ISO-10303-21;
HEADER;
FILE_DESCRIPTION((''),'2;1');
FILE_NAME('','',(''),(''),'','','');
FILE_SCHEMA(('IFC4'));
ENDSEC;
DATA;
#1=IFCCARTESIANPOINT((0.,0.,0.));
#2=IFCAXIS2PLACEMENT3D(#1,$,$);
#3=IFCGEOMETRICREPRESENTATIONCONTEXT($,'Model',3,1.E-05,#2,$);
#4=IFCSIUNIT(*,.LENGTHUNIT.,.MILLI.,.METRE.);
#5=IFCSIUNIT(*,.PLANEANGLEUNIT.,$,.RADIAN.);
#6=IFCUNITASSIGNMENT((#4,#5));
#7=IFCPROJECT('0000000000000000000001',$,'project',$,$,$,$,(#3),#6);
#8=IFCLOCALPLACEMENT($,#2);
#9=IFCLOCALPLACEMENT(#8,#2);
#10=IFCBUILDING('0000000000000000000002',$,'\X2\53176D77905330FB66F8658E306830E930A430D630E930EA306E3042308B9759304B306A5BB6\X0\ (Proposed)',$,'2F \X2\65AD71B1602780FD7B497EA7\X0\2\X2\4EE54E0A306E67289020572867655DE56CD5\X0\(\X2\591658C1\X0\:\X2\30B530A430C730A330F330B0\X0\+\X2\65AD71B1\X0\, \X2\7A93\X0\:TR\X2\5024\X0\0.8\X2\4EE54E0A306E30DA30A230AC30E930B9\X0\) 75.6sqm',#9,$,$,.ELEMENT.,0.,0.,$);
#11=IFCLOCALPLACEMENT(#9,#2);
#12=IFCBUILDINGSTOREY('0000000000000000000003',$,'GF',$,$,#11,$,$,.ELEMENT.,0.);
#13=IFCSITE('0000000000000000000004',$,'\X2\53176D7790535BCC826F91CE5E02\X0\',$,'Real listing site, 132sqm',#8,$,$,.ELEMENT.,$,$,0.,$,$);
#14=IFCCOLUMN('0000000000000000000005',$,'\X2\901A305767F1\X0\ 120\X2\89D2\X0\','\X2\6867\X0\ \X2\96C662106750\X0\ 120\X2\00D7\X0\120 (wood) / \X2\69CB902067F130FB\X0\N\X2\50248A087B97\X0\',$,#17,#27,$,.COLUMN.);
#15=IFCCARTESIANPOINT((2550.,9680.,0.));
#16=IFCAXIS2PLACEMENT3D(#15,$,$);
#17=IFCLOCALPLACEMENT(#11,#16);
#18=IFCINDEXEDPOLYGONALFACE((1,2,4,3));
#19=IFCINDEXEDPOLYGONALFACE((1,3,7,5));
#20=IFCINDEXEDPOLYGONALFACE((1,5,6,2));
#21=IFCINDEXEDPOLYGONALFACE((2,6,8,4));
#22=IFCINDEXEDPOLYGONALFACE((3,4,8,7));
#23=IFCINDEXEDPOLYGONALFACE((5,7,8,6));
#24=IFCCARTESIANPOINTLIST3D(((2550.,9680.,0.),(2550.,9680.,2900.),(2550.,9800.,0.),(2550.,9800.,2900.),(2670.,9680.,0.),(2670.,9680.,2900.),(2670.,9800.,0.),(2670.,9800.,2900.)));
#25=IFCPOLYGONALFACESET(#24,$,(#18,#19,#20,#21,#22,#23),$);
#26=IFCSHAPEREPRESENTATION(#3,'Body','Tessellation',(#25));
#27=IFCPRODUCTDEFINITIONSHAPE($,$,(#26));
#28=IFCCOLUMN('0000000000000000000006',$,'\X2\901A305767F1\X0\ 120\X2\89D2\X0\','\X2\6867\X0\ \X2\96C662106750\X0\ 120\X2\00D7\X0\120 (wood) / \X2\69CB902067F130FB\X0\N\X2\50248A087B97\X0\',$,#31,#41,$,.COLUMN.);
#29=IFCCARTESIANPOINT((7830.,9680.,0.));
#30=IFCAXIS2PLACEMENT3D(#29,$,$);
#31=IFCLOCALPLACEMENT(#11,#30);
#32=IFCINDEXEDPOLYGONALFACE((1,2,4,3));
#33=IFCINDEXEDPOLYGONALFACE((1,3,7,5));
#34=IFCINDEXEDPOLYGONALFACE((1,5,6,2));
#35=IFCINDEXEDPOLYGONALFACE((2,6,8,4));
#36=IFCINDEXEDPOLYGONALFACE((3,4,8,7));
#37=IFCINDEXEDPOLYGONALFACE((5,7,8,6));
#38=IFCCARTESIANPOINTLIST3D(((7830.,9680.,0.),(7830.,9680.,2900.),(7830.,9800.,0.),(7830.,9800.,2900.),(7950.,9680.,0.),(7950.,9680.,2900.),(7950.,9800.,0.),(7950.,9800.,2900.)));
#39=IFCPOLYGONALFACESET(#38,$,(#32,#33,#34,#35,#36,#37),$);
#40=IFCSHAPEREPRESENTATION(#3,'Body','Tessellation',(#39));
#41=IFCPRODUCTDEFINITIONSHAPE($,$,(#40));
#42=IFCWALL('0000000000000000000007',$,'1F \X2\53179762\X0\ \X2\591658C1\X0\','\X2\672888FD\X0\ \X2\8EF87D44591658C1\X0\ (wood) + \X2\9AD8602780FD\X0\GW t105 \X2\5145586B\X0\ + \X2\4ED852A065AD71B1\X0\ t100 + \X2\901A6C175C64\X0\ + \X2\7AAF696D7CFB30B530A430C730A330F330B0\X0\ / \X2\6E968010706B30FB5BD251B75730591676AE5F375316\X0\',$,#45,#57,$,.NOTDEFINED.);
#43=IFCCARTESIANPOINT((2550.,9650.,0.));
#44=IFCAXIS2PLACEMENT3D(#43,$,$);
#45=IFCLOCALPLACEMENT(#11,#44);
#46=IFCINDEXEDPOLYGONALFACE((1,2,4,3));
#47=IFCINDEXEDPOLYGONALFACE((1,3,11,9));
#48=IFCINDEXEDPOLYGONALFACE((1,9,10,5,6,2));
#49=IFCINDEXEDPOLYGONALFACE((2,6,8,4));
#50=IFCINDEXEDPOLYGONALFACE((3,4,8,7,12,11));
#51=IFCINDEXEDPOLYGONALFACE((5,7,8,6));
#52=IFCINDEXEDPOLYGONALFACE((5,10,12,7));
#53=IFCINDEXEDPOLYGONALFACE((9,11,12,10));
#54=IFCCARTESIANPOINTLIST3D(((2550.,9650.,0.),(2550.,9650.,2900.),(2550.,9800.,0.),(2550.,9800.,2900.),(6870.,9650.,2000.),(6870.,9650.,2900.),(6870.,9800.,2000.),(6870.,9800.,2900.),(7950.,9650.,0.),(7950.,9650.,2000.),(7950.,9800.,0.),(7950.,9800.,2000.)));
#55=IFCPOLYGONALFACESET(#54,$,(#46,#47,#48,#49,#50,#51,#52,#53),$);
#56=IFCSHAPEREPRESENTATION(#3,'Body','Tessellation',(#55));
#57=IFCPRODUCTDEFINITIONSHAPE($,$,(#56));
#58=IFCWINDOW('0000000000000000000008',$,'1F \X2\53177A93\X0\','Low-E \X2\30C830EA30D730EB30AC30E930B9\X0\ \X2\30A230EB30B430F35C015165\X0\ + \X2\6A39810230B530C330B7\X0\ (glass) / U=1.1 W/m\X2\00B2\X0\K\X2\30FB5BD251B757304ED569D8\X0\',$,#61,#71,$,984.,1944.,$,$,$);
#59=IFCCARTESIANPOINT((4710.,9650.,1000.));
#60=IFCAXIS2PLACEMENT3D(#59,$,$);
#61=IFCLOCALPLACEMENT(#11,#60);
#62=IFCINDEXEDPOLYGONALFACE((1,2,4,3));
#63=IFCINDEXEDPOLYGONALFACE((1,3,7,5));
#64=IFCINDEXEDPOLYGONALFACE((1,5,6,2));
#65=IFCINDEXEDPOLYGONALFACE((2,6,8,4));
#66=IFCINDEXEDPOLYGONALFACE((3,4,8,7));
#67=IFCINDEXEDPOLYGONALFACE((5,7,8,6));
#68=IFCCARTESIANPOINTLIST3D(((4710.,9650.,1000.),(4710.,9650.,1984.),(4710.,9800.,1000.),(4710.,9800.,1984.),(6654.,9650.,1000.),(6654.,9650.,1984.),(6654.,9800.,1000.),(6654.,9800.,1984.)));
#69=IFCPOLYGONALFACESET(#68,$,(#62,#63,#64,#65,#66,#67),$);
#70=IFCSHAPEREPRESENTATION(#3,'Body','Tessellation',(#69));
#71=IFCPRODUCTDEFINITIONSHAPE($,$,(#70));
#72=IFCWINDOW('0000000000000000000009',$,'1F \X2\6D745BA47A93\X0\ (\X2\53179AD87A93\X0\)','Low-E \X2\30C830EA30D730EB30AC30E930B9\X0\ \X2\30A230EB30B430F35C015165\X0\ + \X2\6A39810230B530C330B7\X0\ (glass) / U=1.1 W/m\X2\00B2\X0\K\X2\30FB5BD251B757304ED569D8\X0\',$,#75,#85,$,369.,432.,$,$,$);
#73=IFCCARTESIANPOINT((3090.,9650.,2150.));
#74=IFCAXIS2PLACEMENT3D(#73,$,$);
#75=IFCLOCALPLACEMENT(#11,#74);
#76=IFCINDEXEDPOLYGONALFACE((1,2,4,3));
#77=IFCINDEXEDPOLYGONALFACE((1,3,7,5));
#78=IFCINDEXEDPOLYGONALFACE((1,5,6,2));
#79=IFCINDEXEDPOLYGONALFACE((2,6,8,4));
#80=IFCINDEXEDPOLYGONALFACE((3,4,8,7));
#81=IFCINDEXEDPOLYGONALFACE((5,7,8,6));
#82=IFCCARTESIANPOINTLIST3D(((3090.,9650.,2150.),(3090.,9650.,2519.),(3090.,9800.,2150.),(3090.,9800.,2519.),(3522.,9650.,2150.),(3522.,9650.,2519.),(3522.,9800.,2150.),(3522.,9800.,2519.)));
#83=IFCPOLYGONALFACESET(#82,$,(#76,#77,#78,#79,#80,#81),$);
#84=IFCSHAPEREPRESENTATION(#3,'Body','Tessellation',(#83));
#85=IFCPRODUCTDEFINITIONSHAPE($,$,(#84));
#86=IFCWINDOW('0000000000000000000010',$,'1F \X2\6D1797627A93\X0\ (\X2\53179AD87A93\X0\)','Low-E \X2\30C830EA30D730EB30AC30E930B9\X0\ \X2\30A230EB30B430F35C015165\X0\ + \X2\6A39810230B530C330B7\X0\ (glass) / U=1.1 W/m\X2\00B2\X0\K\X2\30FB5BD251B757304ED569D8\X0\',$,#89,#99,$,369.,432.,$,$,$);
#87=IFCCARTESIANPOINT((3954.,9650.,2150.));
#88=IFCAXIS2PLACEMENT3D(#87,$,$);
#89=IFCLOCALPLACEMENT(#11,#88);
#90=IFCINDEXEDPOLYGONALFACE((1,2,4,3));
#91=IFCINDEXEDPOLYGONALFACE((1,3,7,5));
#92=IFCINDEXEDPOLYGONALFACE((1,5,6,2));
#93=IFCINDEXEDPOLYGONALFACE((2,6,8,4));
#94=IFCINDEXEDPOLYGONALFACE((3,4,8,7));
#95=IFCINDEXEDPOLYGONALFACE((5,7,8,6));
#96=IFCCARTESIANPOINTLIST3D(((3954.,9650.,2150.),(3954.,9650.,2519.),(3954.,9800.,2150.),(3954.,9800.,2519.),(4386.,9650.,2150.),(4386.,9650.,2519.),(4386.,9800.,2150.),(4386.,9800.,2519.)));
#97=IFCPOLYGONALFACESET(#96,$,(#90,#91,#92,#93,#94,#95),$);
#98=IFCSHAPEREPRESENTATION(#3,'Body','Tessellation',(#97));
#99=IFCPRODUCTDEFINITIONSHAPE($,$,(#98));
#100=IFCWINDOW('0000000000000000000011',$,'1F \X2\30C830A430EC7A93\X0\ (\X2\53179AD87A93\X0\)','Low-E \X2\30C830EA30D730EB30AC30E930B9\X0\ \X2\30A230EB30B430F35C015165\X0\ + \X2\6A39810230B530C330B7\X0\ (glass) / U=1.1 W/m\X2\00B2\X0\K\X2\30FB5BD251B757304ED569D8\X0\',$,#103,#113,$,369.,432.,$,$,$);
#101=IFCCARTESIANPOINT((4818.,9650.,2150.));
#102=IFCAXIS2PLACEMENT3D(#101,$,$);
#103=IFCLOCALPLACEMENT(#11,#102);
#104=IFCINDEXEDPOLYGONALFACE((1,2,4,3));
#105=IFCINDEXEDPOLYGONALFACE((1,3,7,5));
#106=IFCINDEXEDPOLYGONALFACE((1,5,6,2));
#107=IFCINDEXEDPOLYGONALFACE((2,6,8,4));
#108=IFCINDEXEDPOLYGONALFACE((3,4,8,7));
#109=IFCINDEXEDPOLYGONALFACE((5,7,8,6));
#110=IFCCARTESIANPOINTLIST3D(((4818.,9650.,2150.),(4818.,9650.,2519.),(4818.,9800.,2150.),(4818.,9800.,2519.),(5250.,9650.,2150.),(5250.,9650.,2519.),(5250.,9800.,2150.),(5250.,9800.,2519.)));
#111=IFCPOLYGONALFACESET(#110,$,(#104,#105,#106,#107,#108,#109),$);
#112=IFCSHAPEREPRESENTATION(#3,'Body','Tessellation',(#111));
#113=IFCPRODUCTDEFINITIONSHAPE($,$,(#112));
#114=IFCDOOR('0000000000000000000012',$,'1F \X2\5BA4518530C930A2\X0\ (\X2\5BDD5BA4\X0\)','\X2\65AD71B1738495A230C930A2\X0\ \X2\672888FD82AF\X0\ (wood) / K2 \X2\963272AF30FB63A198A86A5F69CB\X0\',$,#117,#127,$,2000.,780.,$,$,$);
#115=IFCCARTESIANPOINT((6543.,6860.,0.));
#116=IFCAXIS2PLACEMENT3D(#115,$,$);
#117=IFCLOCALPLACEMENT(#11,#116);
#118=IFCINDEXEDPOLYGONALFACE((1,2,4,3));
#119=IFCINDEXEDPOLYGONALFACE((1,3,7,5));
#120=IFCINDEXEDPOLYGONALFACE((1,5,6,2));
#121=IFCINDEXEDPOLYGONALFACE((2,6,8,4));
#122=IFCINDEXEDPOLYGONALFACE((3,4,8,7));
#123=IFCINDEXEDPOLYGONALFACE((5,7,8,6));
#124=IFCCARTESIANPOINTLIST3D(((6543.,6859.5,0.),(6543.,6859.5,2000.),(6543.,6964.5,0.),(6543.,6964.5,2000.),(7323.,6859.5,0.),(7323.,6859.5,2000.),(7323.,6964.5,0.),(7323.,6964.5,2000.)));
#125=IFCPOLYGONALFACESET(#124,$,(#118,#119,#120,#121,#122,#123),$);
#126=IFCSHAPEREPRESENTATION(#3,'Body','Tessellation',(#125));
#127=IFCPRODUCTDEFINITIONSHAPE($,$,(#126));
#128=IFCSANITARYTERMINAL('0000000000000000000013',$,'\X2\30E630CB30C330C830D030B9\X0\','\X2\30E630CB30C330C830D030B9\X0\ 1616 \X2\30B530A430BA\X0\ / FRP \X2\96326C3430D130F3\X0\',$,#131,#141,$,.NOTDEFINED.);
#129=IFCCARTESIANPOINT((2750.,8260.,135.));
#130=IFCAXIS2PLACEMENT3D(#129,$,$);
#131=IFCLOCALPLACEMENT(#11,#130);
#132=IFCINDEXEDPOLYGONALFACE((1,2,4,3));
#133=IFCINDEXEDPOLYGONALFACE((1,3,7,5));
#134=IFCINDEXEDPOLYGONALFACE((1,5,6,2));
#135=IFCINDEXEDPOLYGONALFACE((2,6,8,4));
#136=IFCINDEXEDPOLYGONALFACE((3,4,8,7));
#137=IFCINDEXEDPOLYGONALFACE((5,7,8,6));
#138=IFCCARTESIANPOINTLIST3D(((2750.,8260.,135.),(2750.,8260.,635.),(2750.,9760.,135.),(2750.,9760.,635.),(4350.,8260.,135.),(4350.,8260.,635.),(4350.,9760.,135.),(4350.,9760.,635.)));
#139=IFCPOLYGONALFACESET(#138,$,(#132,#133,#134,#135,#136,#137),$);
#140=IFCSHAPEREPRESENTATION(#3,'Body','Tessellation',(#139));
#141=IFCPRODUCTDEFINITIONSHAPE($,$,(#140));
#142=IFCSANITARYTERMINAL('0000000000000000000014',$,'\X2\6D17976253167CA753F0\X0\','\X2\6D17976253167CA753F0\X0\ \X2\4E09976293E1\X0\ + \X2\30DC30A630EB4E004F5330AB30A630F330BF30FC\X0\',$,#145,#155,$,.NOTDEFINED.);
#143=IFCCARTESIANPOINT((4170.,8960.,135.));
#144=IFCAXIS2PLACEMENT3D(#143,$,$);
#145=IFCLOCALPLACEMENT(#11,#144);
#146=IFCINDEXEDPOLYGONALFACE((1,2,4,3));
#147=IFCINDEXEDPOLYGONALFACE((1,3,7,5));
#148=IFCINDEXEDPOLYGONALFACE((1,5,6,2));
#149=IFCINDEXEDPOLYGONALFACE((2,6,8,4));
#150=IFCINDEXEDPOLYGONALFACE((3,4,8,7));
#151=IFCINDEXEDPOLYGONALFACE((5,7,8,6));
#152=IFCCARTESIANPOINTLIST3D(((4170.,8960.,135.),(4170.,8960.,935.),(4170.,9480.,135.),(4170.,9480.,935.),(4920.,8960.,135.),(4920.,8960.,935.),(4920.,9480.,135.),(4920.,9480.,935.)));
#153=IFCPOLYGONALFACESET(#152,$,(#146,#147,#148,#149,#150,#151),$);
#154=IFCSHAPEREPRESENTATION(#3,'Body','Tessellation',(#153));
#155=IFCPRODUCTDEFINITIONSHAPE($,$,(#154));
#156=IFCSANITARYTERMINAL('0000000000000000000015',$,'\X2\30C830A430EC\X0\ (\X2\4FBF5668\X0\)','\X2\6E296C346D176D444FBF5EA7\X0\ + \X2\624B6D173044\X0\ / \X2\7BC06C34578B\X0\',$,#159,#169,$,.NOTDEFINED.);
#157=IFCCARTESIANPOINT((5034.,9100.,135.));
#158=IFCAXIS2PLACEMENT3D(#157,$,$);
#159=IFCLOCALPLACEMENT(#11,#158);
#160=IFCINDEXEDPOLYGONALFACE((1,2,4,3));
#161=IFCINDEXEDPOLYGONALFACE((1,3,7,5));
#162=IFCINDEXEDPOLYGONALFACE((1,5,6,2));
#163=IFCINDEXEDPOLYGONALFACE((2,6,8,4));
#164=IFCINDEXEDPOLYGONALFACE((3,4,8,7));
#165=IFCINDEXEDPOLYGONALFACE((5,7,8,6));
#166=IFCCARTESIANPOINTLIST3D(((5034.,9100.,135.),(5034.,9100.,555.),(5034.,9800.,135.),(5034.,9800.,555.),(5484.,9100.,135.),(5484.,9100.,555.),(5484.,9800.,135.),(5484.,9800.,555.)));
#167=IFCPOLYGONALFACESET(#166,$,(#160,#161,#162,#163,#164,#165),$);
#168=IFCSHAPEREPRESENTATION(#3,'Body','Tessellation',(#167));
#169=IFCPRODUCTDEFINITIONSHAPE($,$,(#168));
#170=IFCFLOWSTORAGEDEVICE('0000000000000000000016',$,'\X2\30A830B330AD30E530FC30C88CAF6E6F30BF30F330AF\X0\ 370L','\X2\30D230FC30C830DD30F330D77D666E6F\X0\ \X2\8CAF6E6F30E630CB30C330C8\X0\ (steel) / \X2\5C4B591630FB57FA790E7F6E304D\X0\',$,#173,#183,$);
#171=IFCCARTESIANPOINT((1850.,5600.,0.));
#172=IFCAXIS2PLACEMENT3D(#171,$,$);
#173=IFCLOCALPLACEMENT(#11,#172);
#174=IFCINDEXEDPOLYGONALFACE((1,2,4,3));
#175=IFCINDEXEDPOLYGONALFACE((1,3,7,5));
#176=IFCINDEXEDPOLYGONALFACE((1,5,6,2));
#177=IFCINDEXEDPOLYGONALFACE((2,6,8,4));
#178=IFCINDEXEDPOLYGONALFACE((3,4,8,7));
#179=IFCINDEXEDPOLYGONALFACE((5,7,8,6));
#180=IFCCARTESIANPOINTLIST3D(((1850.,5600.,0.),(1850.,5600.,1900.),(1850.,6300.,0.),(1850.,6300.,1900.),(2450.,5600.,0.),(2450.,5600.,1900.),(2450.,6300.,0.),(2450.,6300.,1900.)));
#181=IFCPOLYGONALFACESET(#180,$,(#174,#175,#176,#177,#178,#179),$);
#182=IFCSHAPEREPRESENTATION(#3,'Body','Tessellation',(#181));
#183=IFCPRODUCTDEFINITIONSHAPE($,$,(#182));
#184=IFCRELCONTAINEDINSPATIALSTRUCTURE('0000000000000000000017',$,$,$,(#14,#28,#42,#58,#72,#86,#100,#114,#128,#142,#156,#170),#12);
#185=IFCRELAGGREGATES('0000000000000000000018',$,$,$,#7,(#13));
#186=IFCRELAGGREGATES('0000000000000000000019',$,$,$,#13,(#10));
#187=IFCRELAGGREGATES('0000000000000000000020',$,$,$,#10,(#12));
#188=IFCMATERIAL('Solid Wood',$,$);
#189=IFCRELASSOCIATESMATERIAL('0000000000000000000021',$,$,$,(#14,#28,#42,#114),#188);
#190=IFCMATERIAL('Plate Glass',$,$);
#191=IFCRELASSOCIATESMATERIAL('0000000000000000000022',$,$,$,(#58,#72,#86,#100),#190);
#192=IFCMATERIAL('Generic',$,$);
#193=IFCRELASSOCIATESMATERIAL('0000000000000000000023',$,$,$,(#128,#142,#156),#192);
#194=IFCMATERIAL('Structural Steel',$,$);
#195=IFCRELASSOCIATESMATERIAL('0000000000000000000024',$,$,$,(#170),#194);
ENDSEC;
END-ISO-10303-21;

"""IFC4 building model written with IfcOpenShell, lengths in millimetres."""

from ifc_helpers import new_model, si_unit, frame, frame_2d, origin, place, context, project, spatial, rectangle, extrude, material, element, fill, save


model = new_model("IFC4")

# Units and contexts
model_context = context("Model", 3, precision=1e-05, world=origin())
ifc_project = project(units=[si_unit("LENGTHUNIT", "METRE", prefix="MILLI"), si_unit("PLANEANGLEUNIT", "RADIAN")], contexts=[model_context])

# Site, building, storey
site_placement = place(None, origin())
site = spatial("IfcSite", under=ifc_project, at=site_placement, Name="北海道富良野市", ObjectType="Real listing site, 132sqm", CompositionType="ELEMENT", RefElevation=0.0)
building_placement = place(site_placement, origin())
building = spatial("IfcBuilding", under=site, at=building_placement, Name="北海道・書斎とライブラリのある静かな家 (Proposed)", ObjectType="2F 断熱性能等级2以上の木造在来工法(外壁:サイディング+断熱, 窓:TR値0.8以上のペアガラス) 75.6sqm", CompositionType="ELEMENT", ElevationOfRefHeight=0.0, ElevationOfTerrain=0.0)
storey_placement = place(building_placement, origin())
storey = spatial("IfcBuildingStorey", under=building, at=storey_placement, Name="GF", CompositionType="ELEMENT", Elevation=0.0)

# Columns
ifc_material_1 = material(Name="Solid Wood")
column_1_placement = place(storey_placement, frame((2550.0, 9680.0, 0.0)))
element("IfcColumn", 1, at=column_1_placement, inside=storey, material=ifc_material_1, Name="通し柱 120角", Description="桧 集成材 120×120 (wood) / 構造柱・N値計算", PredefinedType="COLUMN", context=model_context, shape_type="SweptSolid", body=[
    extrude(rectangle(XDim=120.0, YDim=120.0, at=frame_2d((60.0, 60.0))), frame((2550.0, 9680.0, 0.0)), (0.0, 0.0, 1.0), 2900.0),
])
column_2_placement = place(storey_placement, frame((7830.0, 9680.0, 0.0)))
element("IfcColumn", 2, at=column_2_placement, inside=storey, material=ifc_material_1, Name="通し柱 120角", Description="桧 集成材 120×120 (wood) / 構造柱・N値計算", PredefinedType="COLUMN", context=model_context, shape_type="SweptSolid", body=[
    extrude(rectangle(XDim=120.0, YDim=120.0, at=frame_2d((60.0, 60.0))), frame((7830.0, 9680.0, 0.0)), (0.0, 0.0, 1.0), 2900.0),
])

# Wall, openings, windows
wall_1_placement = place(storey_placement, frame((2550.0, 9650.0, 0.0)))
wall_1 = element("IfcWall", 3, at=wall_1_placement, inside=storey, material=ifc_material_1, Name="1F 北面 外壁", Description="木製 軸組外壁 (wood) + 高性能GW t105 充填 + 付加断熱 t100 + 通気層 + 窯業系サイディング / 準耐火・寒冷地外皮強化", PredefinedType="NOTDEFINED", context=model_context, shape_type="SweptSolid", body=[
    extrude(rectangle(XDim=5400.0, YDim=150.0, at=frame_2d((2700.0, 75.0))), frame((2550.0, 9650.0, 0.0)), (0.0, 0.0, 1.0), 2900.0),
])
opening_1_placement = place(storey_placement, frame((4710.0, 9650.0, 1000.0)))
opening_1 = element("IfcOpeningElement", 4, at=opening_1_placement, cuts=wall_1, PredefinedType="NOTDEFINED", context=model_context, shape_type="SweptSolid", body=[
    extrude(rectangle(XDim=1944.0, YDim=150.0, at=frame_2d((972.0, 75.0))), frame((4710.0, 9650.0, 1000.0)), (0.0, 0.0, 1.0), 984.0),
])
opening_2_placement = place(storey_placement, frame((3090.0, 9650.0, 2150.0)))
opening_2 = element("IfcOpeningElement", 5, at=opening_2_placement, cuts=wall_1, PredefinedType="NOTDEFINED", context=model_context, shape_type="SweptSolid", body=[
    extrude(rectangle(XDim=432.0, YDim=150.0, at=frame_2d((216.0, 75.0))), frame((3090.0, 9650.0, 2150.0)), (0.0, 0.0, 1.0), 369.0),
])
opening_3_placement = place(storey_placement, frame((3954.0, 9650.0, 2150.0)))
opening_3 = element("IfcOpeningElement", 6, at=opening_3_placement, cuts=wall_1, PredefinedType="NOTDEFINED", context=model_context, shape_type="SweptSolid", body=[
    extrude(rectangle(XDim=432.0, YDim=150.0, at=frame_2d((216.0, 75.0))), frame((3954.0, 9650.0, 2150.0)), (0.0, 0.0, 1.0), 369.0),
])
opening_4_placement = place(storey_placement, frame((4818.0, 9650.0, 2150.0)))
opening_4 = element("IfcOpeningElement", 7, at=opening_4_placement, cuts=wall_1, PredefinedType="NOTDEFINED", context=model_context, shape_type="SweptSolid", body=[
    extrude(rectangle(XDim=432.0, YDim=150.0, at=frame_2d((216.0, 75.0))), frame((4818.0, 9650.0, 2150.0)), (0.0, 0.0, 1.0), 369.0),
])
ifc_material_2 = material(Name="Plate Glass")
window_1_placement = place(storey_placement, frame((4710.0, 9650.0, 1000.0)))
window_1 = element("IfcWindow", 8, at=window_1_placement, inside=storey, material=ifc_material_2, Name="1F 北窓", Description="Low-E トリプルガラス アルゴン封入 + 樹脂サッシ (glass) / U=1.1 W/m²K・寒冷地仕様", OverallHeight=984.0, OverallWidth=1944.0, context=model_context, shape_type="SweptSolid", body=[
    extrude(rectangle(XDim=1944.0, YDim=150.0, at=frame_2d((972.0, 75.0))), frame((4710.0, 9650.0, 1000.0)), (0.0, 0.0, 1.0), 984.0),
])
fill(opening_1, window_1)
window_2_placement = place(storey_placement, frame((3090.0, 9650.0, 2150.0)))
window_2 = element("IfcWindow", 9, at=window_2_placement, inside=storey, material=ifc_material_2, Name="1F 浴室窓 (北高窓)", Description="Low-E トリプルガラス アルゴン封入 + 樹脂サッシ (glass) / U=1.1 W/m²K・寒冷地仕様", OverallHeight=369.0, OverallWidth=432.0, context=model_context, shape_type="SweptSolid", body=[
    extrude(rectangle(XDim=432.0, YDim=150.0, at=frame_2d((216.0, 75.0))), frame((3090.0, 9650.0, 2150.0)), (0.0, 0.0, 1.0), 369.0),
])
fill(opening_2, window_2)
window_3_placement = place(storey_placement, frame((3954.0, 9650.0, 2150.0)))
window_3 = element("IfcWindow", 10, at=window_3_placement, inside=storey, material=ifc_material_2, Name="1F 洗面窓 (北高窓)", Description="Low-E トリプルガラス アルゴン封入 + 樹脂サッシ (glass) / U=1.1 W/m²K・寒冷地仕様", OverallHeight=369.0, OverallWidth=432.0, context=model_context, shape_type="SweptSolid", body=[
    extrude(rectangle(XDim=432.0, YDim=150.0, at=frame_2d((216.0, 75.0))), frame((3954.0, 9650.0, 2150.0)), (0.0, 0.0, 1.0), 369.0),
])
fill(opening_3, window_3)
window_4_placement = place(storey_placement, frame((4818.0, 9650.0, 2150.0)))
window_4 = element("IfcWindow", 11, at=window_4_placement, inside=storey, material=ifc_material_2, Name="1F トイレ窓 (北高窓)", Description="Low-E トリプルガラス アルゴン封入 + 樹脂サッシ (glass) / U=1.1 W/m²K・寒冷地仕様", OverallHeight=369.0, OverallWidth=432.0, context=model_context, shape_type="SweptSolid", body=[
    extrude(rectangle(XDim=432.0, YDim=150.0, at=frame_2d((216.0, 75.0))), frame((4818.0, 9650.0, 2150.0)), (0.0, 0.0, 1.0), 369.0),
])
fill(opening_4, window_4)

# Door
door_1_placement = place(storey_placement, frame((6543.0, 6860.0, 0.0)))
element("IfcDoor", 12, at=door_1_placement, inside=storey, material=ifc_material_1, Name="1F 室内ドア (寝室)", Description="断熱玄関ドア 木製芯 (wood) / K2 防犯・採風機構", OverallHeight=2000.0, OverallWidth=780.0, context=model_context, shape_type="SweptSolid", body=[
    extrude(rectangle(XDim=780.0, YDim=105.0, at=frame_2d((390.0, 52.0))), frame((6543.0, 6860.0, 0.0)), (0.0, 0.0, 1.0), 2000.0),
])

# Sanitary terminals
ifc_material_3 = material(Name="Generic")
sanitary_terminal_1_placement = place(storey_placement, frame((2750.0, 8260.0, 135.0)))
element("IfcSanitaryTerminal", 13, at=sanitary_terminal_1_placement, inside=storey, material=ifc_material_3, Name="ユニットバス", Description="ユニットバス 1616 サイズ / FRP 防水パン", PredefinedType="NOTDEFINED", context=model_context, shape_type="SweptSolid", body=[
    extrude(rectangle(XDim=1600.0, YDim=1500.0, at=frame_2d((800.0, 750.0))), frame((2750.0, 8260.0, 135.0)), (0.0, 0.0, 1.0), 500.0),
])
sanitary_terminal_2_placement = place(storey_placement, frame((4170.0, 8960.0, 135.0)))
element("IfcSanitaryTerminal", 14, at=sanitary_terminal_2_placement, inside=storey, material=ifc_material_3, Name="洗面化粧台", Description="洗面化粧台 三面鏡 + ボウル一体カウンター", PredefinedType="NOTDEFINED", context=model_context, shape_type="SweptSolid", body=[
    extrude(rectangle(XDim=750.0, YDim=520.0, at=frame_2d((375.0, 260.0))), frame((4170.0, 8960.0, 135.0)), (0.0, 0.0, 1.0), 800.0),
])
sanitary_terminal_3_placement = place(storey_placement, frame((5034.0, 9100.0, 135.0)))
element("IfcSanitaryTerminal", 15, at=sanitary_terminal_3_placement, inside=storey, material=ifc_material_3, Name="トイレ (便器)", Description="温水洗浄便座 + 手洗い / 節水型", PredefinedType="NOTDEFINED", context=model_context, shape_type="SweptSolid", body=[
    extrude(rectangle(XDim=450.0, YDim=700.0, at=frame_2d((225.0, 350.0))), frame((5034.0, 9100.0, 135.0)), (0.0, 0.0, 1.0), 420.0),
])

# Flow storage device
ifc_material_4 = material(Name="Structural Steel")
flow_storage_device_placement = place(storey_placement, frame((1850.0, 5600.0, 0.0)))
element("IfcFlowStorageDevice", 16, at=flow_storage_device_placement, inside=storey, material=ifc_material_4, Name="エコキュート貯湯タンク 370L", Description="ヒートポンプ給湯 貯湯ユニット (steel) / 屋外・基礎置き", context=model_context, shape_type="SweptSolid", body=[
    extrude(rectangle(XDim=600.0, YDim=700.0, at=frame_2d((300.0, 350.0))), frame((1850.0, 5600.0, 0.0)), (0.0, 0.0, 1.0), 1900.0),
])

save(model, "model.ifc")
